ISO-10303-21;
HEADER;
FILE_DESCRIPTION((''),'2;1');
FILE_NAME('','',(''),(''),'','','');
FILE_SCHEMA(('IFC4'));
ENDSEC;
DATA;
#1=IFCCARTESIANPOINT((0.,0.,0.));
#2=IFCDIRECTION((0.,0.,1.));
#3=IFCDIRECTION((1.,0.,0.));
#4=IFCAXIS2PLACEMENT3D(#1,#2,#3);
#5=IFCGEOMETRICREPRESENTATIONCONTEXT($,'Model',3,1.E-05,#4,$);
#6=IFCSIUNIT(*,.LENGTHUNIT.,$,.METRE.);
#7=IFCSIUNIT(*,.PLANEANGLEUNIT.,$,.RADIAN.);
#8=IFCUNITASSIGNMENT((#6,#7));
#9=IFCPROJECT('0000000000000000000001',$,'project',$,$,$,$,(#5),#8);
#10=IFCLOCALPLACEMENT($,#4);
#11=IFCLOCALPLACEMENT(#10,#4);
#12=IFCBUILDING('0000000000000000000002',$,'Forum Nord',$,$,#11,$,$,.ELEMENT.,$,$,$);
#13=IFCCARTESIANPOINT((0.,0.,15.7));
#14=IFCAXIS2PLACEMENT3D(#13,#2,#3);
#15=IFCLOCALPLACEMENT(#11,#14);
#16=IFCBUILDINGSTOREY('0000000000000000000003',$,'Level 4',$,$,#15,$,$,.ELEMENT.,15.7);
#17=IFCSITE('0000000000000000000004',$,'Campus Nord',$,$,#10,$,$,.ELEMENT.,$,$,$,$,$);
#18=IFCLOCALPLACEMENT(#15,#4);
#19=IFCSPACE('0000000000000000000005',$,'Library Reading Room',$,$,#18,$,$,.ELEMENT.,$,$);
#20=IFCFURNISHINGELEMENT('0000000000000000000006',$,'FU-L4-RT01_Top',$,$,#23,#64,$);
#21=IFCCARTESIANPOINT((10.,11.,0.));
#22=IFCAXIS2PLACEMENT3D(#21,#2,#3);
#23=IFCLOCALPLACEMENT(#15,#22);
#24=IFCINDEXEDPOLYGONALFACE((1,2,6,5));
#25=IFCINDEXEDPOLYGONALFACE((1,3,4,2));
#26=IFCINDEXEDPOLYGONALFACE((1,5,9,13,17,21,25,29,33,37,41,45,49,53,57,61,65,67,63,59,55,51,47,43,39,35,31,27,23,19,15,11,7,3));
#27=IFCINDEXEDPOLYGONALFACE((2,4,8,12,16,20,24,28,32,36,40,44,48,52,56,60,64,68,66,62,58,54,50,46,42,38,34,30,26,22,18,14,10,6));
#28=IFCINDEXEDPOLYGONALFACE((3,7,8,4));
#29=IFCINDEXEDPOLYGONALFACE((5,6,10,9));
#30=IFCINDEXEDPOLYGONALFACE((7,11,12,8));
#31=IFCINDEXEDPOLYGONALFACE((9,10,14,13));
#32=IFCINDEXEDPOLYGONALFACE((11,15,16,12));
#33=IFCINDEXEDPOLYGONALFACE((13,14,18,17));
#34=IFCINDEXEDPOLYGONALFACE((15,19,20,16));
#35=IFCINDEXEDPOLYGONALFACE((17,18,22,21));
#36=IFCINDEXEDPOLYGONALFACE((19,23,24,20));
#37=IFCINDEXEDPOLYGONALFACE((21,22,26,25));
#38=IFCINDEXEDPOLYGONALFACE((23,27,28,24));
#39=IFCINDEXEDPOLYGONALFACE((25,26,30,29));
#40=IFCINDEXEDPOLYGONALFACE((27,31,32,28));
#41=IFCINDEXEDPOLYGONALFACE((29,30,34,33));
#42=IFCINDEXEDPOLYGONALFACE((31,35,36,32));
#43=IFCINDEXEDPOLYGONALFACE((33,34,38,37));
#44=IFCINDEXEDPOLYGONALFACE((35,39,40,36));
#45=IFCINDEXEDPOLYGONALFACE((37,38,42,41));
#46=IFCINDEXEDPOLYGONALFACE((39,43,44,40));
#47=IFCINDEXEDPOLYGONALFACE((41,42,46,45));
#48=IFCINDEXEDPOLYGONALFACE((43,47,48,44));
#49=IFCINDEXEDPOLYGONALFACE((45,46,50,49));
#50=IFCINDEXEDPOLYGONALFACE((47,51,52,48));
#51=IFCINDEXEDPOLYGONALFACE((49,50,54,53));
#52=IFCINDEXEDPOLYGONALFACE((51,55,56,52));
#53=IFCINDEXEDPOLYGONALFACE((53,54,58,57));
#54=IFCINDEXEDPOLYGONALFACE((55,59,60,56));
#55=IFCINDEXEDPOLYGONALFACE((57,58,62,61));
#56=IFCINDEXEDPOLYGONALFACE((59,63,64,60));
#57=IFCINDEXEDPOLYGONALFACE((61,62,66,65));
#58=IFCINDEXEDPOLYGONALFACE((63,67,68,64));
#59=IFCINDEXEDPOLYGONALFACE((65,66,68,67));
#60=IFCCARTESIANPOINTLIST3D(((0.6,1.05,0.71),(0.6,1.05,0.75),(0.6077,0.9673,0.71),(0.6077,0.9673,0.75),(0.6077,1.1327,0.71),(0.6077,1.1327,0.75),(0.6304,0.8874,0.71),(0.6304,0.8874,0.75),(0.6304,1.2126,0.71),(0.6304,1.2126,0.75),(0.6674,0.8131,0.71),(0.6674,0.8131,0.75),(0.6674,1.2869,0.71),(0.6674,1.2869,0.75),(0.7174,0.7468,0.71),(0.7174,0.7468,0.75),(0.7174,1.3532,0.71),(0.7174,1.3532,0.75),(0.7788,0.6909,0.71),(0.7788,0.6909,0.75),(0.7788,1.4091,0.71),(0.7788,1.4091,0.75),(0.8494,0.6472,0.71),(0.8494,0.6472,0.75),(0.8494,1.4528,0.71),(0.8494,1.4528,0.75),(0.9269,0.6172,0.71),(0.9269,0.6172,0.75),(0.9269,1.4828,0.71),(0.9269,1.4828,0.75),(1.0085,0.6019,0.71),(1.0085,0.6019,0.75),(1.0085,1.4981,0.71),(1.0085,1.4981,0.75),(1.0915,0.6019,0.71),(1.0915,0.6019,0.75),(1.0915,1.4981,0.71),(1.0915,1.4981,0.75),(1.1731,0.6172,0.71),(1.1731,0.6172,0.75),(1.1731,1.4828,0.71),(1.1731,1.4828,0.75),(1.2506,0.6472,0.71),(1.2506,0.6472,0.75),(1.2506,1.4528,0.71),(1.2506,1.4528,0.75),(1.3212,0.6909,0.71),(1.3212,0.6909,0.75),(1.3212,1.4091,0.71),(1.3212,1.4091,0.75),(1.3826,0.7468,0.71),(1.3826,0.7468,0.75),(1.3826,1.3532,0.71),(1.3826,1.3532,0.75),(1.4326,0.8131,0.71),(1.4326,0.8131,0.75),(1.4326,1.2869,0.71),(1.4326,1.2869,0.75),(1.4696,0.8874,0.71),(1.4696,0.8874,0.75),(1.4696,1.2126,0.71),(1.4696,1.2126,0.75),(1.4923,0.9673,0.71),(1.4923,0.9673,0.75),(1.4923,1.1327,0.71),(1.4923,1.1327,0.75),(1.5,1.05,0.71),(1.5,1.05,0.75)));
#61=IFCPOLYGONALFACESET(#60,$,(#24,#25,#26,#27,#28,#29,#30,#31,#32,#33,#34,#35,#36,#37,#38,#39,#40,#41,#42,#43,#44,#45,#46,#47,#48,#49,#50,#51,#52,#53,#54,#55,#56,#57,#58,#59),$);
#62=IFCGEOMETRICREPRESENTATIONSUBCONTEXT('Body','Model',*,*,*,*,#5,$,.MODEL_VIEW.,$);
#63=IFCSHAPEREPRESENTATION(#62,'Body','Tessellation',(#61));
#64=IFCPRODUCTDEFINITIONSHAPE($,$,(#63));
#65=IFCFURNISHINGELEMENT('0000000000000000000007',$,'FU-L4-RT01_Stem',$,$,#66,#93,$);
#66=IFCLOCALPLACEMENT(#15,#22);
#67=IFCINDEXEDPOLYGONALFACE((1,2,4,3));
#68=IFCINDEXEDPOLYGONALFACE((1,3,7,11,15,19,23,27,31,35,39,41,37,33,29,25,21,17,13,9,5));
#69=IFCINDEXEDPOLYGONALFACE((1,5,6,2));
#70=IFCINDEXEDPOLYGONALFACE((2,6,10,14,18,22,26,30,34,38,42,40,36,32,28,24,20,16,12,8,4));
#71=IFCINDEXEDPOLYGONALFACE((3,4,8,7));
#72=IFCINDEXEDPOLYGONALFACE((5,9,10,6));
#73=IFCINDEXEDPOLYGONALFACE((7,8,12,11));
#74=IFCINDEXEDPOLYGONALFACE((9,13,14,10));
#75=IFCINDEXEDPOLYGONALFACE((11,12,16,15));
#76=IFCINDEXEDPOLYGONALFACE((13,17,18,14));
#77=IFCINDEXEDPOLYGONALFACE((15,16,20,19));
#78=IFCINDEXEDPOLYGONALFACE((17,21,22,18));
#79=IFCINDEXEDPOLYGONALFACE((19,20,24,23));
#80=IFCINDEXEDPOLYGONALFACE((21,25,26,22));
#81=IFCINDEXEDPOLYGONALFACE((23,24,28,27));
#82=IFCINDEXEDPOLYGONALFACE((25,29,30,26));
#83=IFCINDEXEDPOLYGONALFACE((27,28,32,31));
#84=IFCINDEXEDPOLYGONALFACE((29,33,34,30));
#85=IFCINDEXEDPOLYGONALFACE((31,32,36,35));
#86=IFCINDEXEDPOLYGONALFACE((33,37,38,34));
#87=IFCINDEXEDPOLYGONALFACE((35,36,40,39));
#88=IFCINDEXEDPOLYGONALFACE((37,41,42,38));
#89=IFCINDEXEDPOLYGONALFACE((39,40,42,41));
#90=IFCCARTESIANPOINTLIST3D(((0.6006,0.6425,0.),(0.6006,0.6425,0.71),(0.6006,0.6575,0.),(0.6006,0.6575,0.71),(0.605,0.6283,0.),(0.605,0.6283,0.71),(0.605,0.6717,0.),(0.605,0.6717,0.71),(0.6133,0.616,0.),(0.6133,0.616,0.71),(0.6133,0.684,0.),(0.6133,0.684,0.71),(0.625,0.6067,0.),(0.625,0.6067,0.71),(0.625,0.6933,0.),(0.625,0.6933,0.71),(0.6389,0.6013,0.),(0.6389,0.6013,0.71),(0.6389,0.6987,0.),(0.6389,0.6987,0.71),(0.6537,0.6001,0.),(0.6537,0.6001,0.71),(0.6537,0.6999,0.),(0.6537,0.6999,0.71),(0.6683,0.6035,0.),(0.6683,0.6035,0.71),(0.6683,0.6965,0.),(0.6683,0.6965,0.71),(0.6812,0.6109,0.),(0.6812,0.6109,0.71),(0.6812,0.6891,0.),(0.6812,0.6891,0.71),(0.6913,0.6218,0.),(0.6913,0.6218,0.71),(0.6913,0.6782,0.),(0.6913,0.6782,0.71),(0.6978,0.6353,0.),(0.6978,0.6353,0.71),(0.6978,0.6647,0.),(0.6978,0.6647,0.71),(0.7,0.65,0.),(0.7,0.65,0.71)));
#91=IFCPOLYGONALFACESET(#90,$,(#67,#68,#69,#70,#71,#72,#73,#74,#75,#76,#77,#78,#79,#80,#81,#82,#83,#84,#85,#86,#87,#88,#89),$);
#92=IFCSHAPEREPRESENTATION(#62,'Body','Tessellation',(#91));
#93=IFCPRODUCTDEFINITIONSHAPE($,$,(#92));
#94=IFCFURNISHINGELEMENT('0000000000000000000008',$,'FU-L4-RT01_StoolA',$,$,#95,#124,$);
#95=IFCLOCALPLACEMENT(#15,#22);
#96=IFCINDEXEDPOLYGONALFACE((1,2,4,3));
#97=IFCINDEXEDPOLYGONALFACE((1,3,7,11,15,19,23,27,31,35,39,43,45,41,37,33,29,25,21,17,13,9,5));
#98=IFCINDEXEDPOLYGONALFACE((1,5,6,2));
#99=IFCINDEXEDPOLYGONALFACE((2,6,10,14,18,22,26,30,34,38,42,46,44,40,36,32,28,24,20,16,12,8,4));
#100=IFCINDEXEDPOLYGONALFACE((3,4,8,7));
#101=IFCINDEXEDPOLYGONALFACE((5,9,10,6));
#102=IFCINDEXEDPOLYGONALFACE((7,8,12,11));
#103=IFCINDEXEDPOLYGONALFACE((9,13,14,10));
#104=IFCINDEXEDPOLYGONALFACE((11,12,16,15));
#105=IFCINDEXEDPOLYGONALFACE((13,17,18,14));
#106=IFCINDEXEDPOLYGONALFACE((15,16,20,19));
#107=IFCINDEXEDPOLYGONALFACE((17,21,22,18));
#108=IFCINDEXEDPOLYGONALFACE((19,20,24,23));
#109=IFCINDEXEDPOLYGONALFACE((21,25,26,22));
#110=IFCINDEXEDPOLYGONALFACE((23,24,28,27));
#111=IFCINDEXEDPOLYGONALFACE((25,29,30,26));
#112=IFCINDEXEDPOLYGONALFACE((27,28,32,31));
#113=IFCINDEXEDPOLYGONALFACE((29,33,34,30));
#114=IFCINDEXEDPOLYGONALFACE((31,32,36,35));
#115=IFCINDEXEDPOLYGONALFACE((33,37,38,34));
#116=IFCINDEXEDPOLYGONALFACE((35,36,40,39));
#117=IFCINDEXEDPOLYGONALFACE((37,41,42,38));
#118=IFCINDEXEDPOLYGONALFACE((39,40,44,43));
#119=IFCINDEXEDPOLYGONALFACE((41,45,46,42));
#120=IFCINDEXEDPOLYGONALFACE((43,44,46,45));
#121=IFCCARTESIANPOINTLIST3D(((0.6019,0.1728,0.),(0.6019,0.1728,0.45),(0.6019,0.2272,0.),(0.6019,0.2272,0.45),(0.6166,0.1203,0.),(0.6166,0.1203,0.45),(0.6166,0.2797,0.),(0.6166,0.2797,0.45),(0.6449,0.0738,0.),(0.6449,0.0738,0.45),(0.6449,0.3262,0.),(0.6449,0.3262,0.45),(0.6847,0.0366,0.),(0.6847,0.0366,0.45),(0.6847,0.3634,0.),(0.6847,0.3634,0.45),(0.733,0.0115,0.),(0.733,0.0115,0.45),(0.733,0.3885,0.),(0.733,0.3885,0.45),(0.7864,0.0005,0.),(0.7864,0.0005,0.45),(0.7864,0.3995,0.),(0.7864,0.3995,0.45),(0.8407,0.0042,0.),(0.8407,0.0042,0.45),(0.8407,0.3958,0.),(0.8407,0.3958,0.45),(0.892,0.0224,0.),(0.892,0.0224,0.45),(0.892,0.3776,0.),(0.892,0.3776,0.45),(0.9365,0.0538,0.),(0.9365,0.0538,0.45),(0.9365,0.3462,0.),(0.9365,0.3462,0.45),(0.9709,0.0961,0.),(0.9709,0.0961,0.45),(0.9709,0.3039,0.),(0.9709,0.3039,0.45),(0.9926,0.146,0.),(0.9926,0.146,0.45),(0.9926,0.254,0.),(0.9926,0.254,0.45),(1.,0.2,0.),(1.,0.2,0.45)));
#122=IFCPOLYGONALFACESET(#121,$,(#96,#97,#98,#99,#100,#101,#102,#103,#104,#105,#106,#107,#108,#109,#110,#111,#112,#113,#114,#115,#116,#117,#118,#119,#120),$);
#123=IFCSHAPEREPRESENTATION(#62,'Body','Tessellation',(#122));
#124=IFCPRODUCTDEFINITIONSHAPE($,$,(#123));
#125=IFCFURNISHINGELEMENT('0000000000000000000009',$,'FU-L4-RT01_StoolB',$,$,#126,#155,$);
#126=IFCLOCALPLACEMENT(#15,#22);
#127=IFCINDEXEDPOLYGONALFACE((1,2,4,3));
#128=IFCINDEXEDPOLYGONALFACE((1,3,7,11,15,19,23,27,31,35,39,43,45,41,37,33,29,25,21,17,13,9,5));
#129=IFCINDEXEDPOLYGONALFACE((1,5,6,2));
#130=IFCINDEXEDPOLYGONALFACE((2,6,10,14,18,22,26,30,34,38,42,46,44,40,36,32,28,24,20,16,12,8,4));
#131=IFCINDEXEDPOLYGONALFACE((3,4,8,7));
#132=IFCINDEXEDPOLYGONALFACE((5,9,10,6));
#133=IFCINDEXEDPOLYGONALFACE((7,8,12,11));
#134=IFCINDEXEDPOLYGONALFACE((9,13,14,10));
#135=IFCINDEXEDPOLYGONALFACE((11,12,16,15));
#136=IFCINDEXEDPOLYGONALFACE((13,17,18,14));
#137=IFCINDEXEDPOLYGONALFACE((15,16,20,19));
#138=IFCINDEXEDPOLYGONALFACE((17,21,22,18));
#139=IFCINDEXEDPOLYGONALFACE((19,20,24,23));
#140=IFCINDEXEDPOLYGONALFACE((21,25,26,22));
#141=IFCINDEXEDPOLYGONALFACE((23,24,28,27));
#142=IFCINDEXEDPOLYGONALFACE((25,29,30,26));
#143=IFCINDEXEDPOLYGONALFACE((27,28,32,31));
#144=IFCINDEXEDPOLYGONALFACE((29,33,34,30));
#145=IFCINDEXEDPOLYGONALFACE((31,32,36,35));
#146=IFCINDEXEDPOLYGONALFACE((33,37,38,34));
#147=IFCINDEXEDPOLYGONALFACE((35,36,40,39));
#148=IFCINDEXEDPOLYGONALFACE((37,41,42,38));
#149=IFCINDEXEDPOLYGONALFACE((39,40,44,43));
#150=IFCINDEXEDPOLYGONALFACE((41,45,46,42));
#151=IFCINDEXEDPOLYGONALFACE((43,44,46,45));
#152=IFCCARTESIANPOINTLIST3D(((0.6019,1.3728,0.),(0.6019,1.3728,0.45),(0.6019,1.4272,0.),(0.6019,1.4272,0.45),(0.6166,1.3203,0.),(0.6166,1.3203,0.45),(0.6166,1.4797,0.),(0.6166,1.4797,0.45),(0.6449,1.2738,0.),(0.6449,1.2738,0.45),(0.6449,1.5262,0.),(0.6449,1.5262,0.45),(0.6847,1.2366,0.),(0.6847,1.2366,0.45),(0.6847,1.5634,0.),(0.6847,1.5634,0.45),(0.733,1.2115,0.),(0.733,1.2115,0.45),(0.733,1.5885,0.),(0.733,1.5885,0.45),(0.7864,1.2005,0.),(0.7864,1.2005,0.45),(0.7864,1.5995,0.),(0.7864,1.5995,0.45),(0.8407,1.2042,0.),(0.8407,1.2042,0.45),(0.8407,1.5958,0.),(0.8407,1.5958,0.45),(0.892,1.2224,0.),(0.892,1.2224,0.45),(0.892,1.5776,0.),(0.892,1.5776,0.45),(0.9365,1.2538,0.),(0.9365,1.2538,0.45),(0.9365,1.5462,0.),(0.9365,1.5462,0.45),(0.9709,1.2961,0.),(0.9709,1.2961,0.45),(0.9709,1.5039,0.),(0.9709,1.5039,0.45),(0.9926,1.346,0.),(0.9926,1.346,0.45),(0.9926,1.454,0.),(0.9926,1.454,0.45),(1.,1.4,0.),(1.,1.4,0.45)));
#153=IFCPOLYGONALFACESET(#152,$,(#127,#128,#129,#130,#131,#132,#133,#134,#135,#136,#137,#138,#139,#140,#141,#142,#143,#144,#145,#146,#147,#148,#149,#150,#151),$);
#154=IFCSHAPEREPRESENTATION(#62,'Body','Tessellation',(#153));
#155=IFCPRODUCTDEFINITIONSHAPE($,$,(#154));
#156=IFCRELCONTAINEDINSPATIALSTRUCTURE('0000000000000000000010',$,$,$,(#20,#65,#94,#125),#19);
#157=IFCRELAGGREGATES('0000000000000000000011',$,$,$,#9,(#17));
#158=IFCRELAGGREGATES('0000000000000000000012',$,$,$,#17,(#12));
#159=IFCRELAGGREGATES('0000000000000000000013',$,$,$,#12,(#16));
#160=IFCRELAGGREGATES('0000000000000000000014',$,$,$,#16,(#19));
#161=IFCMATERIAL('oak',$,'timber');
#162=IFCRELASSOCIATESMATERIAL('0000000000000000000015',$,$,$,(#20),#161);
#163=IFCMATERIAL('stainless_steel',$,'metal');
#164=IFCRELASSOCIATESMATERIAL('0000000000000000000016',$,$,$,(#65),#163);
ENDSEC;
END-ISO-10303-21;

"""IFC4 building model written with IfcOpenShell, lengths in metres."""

from ifc_helpers import new_model, si_unit, frame, frame_2d, origin_with_axes, place, context, subcontext, project, spatial, circle, extrude, material, element, save


model = new_model("IFC4")

# Units and contexts
model_context = context("Model", 3, precision=1e-05, world=origin_with_axes())
body_context = subcontext(model_context, "Body", "Model", "MODEL_VIEW")
ifc_project = project(units=[si_unit("LENGTHUNIT", "METRE"), si_unit("PLANEANGLEUNIT", "RADIAN")], contexts=[model_context])

# Site, building, storey
site_placement = place(None, origin_with_axes())
site = spatial("IfcSite", under=ifc_project, at=site_placement, Name="Campus Nord", CompositionType="ELEMENT")
building_placement = place(site_placement, origin_with_axes())
building = spatial("IfcBuilding", under=site, at=building_placement, Name="Forum Nord", CompositionType="ELEMENT")
storey_placement = place(building_placement, frame((0.0, 0.0, 15.7), z_axis=(0.0, 0.0, 1.0), x_axis=(1.0, 0.0, 0.0)))
storey = spatial("IfcBuildingStorey", under=building, at=storey_placement, Name="Level 4", CompositionType="ELEMENT", Elevation=15.7)

# Shared definitions
ifc_material_1 = material(Name="stainless_steel", Category="metal")

# Shared definitions
space_placement = place(storey_placement, origin_with_axes())
space = spatial("IfcSpace", under=storey, at=space_placement, Name="Library Reading Room", CompositionType="ELEMENT")

# Furnishing elements
ifc_material_2 = material(Name="oak", Category="timber")
furnishing_1_placement = place(storey_placement, frame((10.0, 11.0, 0.0), z_axis=(0.0, 0.0, 1.0), x_axis=(1.0, 0.0, 0.0)))
element("IfcFurnishingElement", 1, at=furnishing_1_placement, inside=space, material=ifc_material_2, Name="FU-L4-RT01_Top", context=body_context, shape_type="SweptSolid", body=[
    extrude(circle(Radius=0.45, at=frame_2d((1.05, 1.05), x_axis=(1.0, 0.0))), frame((0.0, 0.0, 0.71), z_axis=(0.0, 0.0, 1.0), x_axis=(1.0, 0.0, 0.0)), (0.0, 0.0, 1.0), 0.04),
])
furnishing_2_placement = place(storey_placement, frame((10.0, 11.0, 0.0), z_axis=(0.0, 0.0, 1.0), x_axis=(1.0, 0.0, 0.0)))
element("IfcFurnishingElement", 2, at=furnishing_2_placement, inside=space, material=ifc_material_1, Name="FU-L4-RT01_Stem", context=body_context, shape_type="SweptSolid", body=[
    extrude(circle(Radius=0.05, at=frame_2d((0.65, 0.65), x_axis=(1.0, 0.0))), origin_with_axes(), (0.0, 0.0, 1.0), 0.71),
])
furnishing_3_placement = place(storey_placement, frame((10.0, 11.0, 0.0), z_axis=(0.0, 0.0, 1.0), x_axis=(1.0, 0.0, 0.0)))
element("IfcFurnishingElement", 3, at=furnishing_3_placement, inside=space, Name="FU-L4-RT01_StoolA", context=body_context, shape_type="SweptSolid", body=[
    extrude(circle(Radius=0.2, at=frame_2d((0.8, 0.2), x_axis=(1.0, 0.0))), origin_with_axes(), (0.0, 0.0, 1.0), 0.45),
])
furnishing_4_placement = place(storey_placement, frame((10.0, 11.0, 0.0), z_axis=(0.0, 0.0, 1.0), x_axis=(1.0, 0.0, 0.0)))
element("IfcFurnishingElement", 4, at=furnishing_4_placement, inside=space, Name="FU-L4-RT01_StoolB", context=body_context, shape_type="SweptSolid", body=[
    extrude(circle(Radius=0.2, at=frame_2d((0.8, 1.4), x_axis=(1.0, 0.0))), origin_with_axes(), (0.0, 0.0, 1.0), 0.45),
])

save(model, "model.ifc")
